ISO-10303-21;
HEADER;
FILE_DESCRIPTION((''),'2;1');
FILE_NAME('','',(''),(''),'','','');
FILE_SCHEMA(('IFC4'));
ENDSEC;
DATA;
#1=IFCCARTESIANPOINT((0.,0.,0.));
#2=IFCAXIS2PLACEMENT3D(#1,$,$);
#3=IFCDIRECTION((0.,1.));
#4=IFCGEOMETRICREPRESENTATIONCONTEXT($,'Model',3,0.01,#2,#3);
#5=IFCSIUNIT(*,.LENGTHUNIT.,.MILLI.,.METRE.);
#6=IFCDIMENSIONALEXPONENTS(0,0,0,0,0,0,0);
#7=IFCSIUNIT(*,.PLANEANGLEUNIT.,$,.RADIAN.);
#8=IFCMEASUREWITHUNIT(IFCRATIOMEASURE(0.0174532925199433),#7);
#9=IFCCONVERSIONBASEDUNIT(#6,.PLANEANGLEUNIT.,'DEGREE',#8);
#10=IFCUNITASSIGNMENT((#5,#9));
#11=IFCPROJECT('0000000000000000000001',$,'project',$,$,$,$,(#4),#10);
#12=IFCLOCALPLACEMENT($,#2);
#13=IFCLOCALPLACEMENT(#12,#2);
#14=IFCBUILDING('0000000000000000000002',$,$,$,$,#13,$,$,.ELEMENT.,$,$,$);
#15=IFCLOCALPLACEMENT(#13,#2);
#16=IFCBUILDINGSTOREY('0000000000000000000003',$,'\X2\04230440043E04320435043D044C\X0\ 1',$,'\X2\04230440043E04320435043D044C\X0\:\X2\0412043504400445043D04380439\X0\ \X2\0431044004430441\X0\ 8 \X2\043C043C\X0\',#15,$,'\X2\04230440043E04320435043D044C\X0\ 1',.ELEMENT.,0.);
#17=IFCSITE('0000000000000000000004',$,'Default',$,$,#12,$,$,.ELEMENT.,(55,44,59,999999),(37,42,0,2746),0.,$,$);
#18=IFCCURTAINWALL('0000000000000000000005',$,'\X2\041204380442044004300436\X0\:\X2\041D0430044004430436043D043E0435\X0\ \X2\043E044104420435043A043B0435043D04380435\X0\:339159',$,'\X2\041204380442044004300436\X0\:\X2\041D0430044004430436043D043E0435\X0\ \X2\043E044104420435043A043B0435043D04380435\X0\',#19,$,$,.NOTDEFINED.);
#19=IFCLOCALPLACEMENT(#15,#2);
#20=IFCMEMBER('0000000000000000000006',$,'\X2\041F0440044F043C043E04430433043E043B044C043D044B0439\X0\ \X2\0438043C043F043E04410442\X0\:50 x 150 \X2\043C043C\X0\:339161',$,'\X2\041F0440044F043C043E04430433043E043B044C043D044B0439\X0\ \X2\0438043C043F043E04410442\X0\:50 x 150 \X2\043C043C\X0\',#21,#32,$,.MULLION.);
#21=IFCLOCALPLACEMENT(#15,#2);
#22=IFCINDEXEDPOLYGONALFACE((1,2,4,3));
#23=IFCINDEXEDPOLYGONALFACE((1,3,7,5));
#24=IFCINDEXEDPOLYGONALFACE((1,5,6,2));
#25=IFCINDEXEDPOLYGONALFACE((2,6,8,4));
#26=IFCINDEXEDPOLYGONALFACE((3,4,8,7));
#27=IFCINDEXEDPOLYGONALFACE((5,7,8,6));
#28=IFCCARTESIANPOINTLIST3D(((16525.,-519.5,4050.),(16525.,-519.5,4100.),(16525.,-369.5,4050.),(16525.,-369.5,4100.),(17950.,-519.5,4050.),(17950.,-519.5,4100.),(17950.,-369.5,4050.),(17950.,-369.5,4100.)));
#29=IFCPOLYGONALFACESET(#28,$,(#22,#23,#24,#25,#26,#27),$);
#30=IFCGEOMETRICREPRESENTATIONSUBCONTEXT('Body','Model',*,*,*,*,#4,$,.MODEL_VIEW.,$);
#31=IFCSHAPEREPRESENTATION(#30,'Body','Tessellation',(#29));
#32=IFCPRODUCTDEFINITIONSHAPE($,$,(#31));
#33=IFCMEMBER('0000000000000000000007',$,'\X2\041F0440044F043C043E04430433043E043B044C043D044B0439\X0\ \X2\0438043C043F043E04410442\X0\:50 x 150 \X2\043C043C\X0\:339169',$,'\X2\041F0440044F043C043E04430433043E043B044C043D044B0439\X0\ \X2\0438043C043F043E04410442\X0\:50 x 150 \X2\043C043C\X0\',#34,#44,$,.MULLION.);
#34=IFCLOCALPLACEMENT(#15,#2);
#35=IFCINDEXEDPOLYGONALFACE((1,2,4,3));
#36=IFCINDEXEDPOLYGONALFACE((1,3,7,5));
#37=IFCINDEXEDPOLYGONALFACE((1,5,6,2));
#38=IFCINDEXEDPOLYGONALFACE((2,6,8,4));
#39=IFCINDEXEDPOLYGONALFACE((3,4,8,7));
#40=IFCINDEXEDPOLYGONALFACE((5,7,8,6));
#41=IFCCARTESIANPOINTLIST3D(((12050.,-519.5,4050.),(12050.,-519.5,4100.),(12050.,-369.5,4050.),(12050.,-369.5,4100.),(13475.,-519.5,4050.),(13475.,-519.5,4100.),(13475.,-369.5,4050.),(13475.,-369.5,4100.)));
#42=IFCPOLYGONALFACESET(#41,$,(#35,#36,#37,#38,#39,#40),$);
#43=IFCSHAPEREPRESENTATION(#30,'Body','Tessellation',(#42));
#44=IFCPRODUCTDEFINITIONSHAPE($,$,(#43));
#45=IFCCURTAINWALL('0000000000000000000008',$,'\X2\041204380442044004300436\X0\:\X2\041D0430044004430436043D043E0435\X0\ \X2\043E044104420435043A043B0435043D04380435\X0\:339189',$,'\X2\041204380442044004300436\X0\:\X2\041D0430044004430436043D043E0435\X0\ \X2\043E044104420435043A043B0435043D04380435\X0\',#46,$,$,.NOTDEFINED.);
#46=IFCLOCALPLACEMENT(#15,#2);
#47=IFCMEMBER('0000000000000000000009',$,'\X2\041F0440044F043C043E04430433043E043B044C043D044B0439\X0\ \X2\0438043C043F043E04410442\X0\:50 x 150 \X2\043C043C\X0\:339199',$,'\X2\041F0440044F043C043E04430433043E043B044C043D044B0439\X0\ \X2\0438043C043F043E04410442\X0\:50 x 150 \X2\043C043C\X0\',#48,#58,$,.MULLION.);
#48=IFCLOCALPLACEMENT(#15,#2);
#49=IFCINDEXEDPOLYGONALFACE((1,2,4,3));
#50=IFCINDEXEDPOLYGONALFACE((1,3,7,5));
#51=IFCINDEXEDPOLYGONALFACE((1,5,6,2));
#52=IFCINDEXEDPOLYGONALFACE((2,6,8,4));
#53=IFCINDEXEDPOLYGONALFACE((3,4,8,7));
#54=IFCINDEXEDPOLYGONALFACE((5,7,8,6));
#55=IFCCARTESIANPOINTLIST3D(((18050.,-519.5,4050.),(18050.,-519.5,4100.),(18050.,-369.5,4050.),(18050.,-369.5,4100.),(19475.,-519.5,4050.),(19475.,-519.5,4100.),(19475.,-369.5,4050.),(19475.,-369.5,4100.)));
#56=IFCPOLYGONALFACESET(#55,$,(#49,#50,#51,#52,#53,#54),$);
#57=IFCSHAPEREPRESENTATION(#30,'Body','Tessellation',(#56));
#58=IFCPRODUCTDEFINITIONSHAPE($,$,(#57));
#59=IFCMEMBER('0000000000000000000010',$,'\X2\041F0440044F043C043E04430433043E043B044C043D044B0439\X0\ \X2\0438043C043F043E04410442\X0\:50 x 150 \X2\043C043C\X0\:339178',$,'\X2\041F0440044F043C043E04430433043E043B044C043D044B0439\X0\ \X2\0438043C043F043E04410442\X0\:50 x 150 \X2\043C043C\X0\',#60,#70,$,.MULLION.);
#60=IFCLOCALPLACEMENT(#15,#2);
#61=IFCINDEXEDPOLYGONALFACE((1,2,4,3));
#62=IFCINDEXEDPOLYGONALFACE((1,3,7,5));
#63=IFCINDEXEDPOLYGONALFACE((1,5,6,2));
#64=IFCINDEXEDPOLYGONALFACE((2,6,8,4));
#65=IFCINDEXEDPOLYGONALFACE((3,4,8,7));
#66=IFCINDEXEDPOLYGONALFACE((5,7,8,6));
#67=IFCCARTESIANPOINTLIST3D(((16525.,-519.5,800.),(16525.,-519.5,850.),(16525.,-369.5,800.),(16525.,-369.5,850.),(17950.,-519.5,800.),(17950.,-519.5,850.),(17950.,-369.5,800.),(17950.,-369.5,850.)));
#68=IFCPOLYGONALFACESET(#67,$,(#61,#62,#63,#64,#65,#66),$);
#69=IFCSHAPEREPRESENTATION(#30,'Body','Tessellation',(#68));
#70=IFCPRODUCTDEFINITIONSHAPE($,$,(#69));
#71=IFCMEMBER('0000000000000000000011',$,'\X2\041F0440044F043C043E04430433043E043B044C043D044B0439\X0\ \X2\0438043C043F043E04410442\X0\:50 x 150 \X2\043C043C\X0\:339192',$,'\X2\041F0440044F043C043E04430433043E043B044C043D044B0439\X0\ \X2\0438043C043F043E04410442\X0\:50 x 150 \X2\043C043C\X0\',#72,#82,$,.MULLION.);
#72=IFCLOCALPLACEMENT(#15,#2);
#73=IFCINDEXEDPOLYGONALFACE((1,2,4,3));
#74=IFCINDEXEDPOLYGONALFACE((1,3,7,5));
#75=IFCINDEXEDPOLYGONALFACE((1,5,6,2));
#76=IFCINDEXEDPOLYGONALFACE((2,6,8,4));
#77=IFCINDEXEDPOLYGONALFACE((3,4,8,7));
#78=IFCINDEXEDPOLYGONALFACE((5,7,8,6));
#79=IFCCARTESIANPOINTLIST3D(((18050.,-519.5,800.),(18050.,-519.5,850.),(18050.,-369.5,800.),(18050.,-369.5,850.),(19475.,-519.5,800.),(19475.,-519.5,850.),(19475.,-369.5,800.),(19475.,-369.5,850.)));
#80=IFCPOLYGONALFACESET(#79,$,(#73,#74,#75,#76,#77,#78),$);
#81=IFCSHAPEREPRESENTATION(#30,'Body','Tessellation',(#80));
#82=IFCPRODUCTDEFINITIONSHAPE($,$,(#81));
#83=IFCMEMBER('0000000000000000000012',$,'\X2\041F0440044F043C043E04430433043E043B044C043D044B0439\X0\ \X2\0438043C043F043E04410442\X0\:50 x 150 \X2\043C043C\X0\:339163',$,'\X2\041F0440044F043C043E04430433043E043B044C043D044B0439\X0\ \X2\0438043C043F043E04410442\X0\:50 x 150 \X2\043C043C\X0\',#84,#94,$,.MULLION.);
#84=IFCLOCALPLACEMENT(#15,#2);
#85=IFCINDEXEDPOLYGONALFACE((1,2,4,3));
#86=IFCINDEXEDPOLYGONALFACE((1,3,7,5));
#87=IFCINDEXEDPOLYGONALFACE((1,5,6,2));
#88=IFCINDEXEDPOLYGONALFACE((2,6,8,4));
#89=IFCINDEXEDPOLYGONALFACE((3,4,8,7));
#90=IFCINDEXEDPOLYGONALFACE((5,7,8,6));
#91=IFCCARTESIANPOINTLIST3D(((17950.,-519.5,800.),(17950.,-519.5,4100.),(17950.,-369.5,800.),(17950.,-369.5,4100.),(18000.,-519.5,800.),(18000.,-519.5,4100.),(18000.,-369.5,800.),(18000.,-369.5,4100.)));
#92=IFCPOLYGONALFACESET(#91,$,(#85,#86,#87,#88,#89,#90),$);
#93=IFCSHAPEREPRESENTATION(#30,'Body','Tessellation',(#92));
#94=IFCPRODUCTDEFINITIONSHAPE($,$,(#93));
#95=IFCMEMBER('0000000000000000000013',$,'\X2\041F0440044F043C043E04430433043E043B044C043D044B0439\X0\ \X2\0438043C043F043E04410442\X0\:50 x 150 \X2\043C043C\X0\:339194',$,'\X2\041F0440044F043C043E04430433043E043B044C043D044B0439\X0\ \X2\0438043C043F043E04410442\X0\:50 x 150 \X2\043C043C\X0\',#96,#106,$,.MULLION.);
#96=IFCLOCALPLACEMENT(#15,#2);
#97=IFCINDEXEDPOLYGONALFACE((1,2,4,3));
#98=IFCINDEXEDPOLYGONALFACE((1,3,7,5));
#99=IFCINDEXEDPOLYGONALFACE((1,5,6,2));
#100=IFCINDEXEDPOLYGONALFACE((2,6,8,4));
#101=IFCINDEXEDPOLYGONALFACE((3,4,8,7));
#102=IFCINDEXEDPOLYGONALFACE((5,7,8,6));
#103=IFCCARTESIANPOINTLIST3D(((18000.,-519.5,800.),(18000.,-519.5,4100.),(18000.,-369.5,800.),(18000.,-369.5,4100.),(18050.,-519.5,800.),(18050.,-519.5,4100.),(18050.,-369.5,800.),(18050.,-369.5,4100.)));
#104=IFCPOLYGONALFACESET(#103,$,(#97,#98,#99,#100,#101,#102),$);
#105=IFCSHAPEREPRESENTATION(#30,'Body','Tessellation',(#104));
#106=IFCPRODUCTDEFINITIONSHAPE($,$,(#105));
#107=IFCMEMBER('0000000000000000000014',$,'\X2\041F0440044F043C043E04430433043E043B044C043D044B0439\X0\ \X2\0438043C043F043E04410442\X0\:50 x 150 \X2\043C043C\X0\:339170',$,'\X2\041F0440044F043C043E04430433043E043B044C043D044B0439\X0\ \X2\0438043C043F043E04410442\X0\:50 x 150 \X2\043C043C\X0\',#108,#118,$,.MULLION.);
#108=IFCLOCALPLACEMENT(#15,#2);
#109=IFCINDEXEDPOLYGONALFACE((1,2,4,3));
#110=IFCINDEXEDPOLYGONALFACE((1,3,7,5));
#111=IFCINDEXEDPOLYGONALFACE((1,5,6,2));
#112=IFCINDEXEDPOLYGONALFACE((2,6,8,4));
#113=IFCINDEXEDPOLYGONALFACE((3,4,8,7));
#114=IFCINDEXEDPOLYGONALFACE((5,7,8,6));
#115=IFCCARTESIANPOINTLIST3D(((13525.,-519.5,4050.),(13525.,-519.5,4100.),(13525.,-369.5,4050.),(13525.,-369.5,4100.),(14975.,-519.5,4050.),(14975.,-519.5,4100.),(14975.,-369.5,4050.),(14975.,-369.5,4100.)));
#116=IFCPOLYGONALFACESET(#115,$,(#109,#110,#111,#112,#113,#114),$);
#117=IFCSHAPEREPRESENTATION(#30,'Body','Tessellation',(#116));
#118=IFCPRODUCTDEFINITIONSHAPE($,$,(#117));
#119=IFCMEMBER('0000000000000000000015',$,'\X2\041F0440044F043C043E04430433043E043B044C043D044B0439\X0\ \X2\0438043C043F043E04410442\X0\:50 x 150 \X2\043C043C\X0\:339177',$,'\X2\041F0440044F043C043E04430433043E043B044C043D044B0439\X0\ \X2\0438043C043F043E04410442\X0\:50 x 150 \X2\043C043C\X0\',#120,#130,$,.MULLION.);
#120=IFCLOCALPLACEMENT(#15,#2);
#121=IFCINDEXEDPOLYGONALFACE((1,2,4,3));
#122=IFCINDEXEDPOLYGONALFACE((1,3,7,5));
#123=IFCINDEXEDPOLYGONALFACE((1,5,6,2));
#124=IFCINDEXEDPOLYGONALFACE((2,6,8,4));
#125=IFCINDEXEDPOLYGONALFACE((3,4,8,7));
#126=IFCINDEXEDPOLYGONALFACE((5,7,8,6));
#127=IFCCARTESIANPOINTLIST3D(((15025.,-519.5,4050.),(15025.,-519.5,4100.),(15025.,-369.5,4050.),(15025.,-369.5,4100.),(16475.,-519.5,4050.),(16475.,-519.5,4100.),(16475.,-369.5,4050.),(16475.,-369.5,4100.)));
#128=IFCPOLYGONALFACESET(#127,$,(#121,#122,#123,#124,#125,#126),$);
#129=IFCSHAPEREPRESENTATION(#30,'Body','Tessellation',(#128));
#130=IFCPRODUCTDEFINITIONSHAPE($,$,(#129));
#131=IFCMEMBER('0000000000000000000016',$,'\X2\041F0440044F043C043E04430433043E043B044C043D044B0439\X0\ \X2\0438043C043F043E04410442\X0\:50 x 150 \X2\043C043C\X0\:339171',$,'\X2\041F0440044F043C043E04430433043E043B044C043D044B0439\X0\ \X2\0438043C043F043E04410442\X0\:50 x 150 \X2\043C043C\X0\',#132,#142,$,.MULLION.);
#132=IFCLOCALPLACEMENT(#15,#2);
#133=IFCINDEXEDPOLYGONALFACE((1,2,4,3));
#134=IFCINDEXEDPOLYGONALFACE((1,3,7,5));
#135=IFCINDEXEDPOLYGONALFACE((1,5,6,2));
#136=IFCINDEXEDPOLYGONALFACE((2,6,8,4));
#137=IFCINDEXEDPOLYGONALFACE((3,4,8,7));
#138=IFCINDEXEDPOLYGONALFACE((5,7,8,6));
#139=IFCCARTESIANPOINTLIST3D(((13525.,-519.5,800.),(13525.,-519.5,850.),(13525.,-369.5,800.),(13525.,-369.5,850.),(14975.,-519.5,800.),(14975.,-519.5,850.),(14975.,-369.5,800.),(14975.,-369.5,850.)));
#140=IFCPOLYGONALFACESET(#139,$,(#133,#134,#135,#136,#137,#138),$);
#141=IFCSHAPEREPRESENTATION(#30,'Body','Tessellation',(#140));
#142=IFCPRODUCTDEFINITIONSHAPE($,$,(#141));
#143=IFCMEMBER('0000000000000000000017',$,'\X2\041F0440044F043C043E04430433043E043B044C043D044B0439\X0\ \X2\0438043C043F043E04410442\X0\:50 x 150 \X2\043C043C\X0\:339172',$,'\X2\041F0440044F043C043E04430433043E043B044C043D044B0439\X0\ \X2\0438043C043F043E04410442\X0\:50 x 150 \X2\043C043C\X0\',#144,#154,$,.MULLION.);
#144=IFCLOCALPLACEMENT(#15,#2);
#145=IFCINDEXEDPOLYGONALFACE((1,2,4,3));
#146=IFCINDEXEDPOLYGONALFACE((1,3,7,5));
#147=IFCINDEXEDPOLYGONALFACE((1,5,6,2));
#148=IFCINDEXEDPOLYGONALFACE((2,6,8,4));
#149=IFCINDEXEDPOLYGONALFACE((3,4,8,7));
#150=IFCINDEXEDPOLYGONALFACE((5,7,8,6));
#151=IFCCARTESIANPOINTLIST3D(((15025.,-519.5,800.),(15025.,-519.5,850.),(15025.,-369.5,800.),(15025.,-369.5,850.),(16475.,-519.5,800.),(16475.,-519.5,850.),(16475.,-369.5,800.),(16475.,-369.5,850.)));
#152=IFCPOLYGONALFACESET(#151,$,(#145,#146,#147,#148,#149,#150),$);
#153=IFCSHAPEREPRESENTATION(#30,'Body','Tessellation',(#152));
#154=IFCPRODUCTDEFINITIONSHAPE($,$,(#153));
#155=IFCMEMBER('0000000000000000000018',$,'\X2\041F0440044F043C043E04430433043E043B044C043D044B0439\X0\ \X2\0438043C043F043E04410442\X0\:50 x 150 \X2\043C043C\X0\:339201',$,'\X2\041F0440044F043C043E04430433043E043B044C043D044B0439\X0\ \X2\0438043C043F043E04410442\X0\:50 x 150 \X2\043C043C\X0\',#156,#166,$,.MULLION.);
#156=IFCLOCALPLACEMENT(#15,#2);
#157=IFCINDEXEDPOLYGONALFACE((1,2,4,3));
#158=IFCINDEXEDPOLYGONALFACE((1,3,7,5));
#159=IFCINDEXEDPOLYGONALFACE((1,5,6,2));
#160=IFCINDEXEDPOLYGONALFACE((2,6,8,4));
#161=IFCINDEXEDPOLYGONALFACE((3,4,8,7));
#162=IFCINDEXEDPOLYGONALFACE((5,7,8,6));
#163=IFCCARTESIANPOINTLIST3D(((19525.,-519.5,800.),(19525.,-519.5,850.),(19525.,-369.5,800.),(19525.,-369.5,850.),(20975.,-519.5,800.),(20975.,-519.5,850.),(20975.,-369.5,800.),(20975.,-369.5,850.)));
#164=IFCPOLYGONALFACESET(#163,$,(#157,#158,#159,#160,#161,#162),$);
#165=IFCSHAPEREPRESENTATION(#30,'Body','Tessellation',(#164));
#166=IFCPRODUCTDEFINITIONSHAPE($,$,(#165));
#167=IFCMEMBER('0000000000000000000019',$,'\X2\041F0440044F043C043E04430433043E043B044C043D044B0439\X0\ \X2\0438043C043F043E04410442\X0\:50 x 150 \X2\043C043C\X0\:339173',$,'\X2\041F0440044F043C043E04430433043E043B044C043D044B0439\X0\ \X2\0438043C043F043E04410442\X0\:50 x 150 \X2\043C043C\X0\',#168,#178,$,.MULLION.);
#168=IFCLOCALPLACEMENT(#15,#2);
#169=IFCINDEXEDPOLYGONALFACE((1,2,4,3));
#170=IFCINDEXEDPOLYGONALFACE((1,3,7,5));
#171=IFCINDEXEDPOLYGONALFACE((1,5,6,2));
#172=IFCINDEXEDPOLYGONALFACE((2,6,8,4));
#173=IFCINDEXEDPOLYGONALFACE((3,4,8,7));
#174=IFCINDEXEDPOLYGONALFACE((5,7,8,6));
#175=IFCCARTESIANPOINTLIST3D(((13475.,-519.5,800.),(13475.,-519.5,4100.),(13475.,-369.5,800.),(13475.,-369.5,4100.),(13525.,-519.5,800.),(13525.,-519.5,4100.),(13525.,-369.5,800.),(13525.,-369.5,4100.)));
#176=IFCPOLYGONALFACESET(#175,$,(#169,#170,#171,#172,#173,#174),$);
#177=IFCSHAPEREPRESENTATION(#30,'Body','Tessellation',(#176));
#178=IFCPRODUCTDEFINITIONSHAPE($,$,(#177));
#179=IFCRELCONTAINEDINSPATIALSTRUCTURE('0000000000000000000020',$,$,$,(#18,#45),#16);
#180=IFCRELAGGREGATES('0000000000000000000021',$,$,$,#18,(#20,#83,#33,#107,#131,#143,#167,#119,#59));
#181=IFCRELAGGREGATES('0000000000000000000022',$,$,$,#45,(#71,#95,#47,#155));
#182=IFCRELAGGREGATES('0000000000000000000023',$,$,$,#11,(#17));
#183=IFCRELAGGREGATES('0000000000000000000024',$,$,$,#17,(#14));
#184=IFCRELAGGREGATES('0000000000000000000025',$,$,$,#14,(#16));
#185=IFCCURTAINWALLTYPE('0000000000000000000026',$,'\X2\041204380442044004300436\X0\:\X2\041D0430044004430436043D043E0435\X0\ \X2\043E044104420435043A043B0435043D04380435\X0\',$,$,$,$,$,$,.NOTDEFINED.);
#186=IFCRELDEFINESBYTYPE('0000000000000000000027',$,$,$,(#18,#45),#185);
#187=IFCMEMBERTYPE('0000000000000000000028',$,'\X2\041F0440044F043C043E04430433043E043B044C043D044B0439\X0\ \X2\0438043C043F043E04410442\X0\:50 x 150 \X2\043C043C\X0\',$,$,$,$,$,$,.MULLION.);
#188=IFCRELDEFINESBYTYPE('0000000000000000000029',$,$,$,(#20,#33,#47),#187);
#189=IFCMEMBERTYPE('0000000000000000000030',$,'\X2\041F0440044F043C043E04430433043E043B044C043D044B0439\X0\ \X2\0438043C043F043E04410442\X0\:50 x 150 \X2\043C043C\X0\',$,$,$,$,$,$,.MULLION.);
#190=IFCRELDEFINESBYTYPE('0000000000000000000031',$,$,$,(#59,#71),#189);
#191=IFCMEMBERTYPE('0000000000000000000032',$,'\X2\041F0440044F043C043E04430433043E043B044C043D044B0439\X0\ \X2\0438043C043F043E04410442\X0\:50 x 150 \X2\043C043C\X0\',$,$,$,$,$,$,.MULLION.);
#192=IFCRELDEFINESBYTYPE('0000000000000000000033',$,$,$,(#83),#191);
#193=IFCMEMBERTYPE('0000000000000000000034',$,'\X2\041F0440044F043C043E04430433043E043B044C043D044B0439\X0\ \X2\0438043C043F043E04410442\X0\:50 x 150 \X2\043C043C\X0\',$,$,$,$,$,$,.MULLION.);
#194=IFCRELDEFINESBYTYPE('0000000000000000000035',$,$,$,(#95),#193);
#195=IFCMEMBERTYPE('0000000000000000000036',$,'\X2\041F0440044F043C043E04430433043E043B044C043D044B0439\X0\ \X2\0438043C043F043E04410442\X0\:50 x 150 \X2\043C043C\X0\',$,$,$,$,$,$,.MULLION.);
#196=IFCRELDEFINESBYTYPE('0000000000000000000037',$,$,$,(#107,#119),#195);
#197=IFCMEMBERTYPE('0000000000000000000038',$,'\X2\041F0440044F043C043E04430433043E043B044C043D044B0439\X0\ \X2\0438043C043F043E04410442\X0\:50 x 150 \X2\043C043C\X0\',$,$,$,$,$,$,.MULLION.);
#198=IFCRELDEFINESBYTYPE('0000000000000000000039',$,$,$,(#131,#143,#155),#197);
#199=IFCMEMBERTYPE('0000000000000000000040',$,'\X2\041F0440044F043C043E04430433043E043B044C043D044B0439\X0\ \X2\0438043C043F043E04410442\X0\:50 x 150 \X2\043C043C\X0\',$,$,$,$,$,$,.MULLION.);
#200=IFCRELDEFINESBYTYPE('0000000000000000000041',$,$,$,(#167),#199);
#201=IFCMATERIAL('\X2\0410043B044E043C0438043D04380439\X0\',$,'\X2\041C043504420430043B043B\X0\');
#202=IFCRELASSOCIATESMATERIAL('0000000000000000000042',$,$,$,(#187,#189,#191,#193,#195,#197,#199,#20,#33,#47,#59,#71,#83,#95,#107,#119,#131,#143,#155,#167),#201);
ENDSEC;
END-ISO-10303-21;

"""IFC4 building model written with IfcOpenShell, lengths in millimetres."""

from ifc_helpers import new_model, entity, si_unit, converted_unit, direction, frame, origin, origin_2d_with_axis, place, context, subcontext, project, spatial, rectangle, extrude, source, transform, mapped, material, material_profile, profile_set, profile_usage, type_object, type_shapes, element, aggregate, save


model = new_model("IFC4")

# Units and contexts
model_context = context("Model", 3, precision=0.01, world=origin(), true_north=direction((0.0, 1.0)))
body_context = subcontext(model_context, "Body", "Model", "MODEL_VIEW")
ifc_project = project(units=[si_unit("LENGTHUNIT", "METRE", prefix="MILLI"), converted_unit("PLANEANGLEUNIT", "DEGREE", entity("IfcRatioMeasure", 0.0174532925199433), si_unit("PLANEANGLEUNIT", "RADIAN"), dimensions=[0, 0, 0, 0, 0, 0, 0])], contexts=[model_context])

# Site, building, storey
site_placement = place(None, origin())
site = spatial("IfcSite", under=ifc_project, at=site_placement, Name="Default", CompositionType="ELEMENT", RefLatitude=(55, 44, 59, 999999), RefLongitude=(37, 42, 0, 2746), RefElevation=0.0)
building_placement = place(site_placement, origin())
building = spatial("IfcBuilding", under=site, at=building_placement, CompositionType="ELEMENT")
storey_placement = place(building_placement, origin())
storey = spatial("IfcBuildingStorey", under=building, at=storey_placement, Name="Уровень 1", ObjectType="Уровень:Верхний брус 8 мм", LongName="Уровень 1", CompositionType="ELEMENT", Elevation=0.0)

# Curtain wall, members
curtain_wall_type = type_object("IfcCurtainWallType", Name="Витраж:Наружное остекление", PredefinedType="NOTDEFINED")
curtain_wall_1_placement = place(storey_placement, origin())
curtain_wall_1 = element("IfcCurtainWall", 1, at=curtain_wall_1_placement, inside=storey, type_object=curtain_wall_type, Name="Витраж:Наружное остекление:339159", ObjectType="Витраж:Наружное остекление", PredefinedType="NOTDEFINED")
ifc_material_1 = material(Name="Алюминий", Category="Металл")
ifc_material_profile = material_profile(ifc_material_1, rectangle(XDim=150.0, YDim=50.0, at=origin_2d_with_axis()), Name="50 x 150 мм")
ifc_profile_set = profile_set([ifc_material_profile], Name="50 x 150 мм")
ifc_profile_usage_1 = profile_usage(ifc_profile_set)
member_type_1 = type_object("IfcMemberType", Name="Прямоугольный импост:50 x 150 мм", PredefinedType="MULLION", material=ifc_profile_set)
shared_shape_1 = source(origin(), body_context, "Body", "SweptSolid", [
    extrude(rectangle(XDim=150.0, YDim=50.0, at=origin_2d_with_axis()), frame((-25.0, 0.0, -1425.0), z_axis=(0.0, 0.0, 1.0), x_axis=(0.0, -1.0, 0.0)), (0.0, 0.0, 1.0), 1425.0),
])
type_shapes(member_type_1, [shared_shape_1])
member_1_placement = place(storey_placement, frame((17950.0, -444.5, 4100.0), z_axis=(1.0, 0.0, 0.0), x_axis=(0.0, 0.0, 1.0)))
member_1 = element("IfcMember", 2, at=member_1_placement, type_object=member_type_1, material=ifc_profile_usage_1, Name="Прямоугольный импост:50 x 150 мм:339161", ObjectType="Прямоугольный импост:50 x 150 мм", PredefinedType="MULLION", context=body_context, shape_type="MappedRepresentation", body=[
    mapped(shared_shape_1, transform((0.0, 0.0, 0.0), scale=1.0)),
])
ifc_profile_usage_2 = profile_usage(ifc_profile_set)
member_2_placement = place(storey_placement, frame((13475.0, -444.5, 4100.0), z_axis=(1.0, 0.0, 0.0), x_axis=(0.0, 0.0, 1.0)))
member_2 = element("IfcMember", 3, at=member_2_placement, type_object=member_type_1, material=ifc_profile_usage_2, Name="Прямоугольный импост:50 x 150 мм:339169", ObjectType="Прямоугольный импост:50 x 150 мм", PredefinedType="MULLION", context=body_context, shape_type="MappedRepresentation", body=[
    mapped(shared_shape_1, transform((0.0, 0.0, 0.0), scale=1.0)),
])

# Curtain wall, member
curtain_wall_2_placement = place(storey_placement, origin())
curtain_wall_2 = element("IfcCurtainWall", 4, at=curtain_wall_2_placement, inside=storey, type_object=curtain_wall_type, Name="Витраж:Наружное остекление:339189", ObjectType="Витраж:Наружное остекление", PredefinedType="NOTDEFINED")
ifc_profile_usage_3 = profile_usage(ifc_profile_set)
member_3_placement = place(storey_placement, frame((19475.0, -444.5, 4100.0), z_axis=(1.0, 0.0, 0.0), x_axis=(0.0, 0.0, 1.0)))
member_3 = element("IfcMember", 5, at=member_3_placement, type_object=member_type_1, material=ifc_profile_usage_3, Name="Прямоугольный импост:50 x 150 мм:339199", ObjectType="Прямоугольный импост:50 x 150 мм", PredefinedType="MULLION", context=body_context, shape_type="MappedRepresentation", body=[
    mapped(shared_shape_1, transform((0.0, 0.0, 0.0), scale=1.0)),
])

# Members
ifc_profile_usage_4 = profile_usage(ifc_profile_set)
member_type_2 = type_object("IfcMemberType", Name="Прямоугольный импост:50 x 150 мм", PredefinedType="MULLION", material=ifc_profile_set)
shared_shape_2 = source(origin(), body_context, "Body", "SweptSolid", [
    extrude(rectangle(XDim=150.0, YDim=50.0, at=origin_2d_with_axis()), frame((-25.0, 0.0, -1425.0), z_axis=(0.0, 0.0, 1.0), x_axis=(0.0, -1.0, 0.0)), (0.0, 0.0, 1.0), 1425.0),
])
type_shapes(member_type_2, [shared_shape_2])
member_4_placement = place(storey_placement, frame((16525.0, -444.5, 800.0), z_axis=(-1.0, 0.0, 0.0), x_axis=(0.0, 0.0, -1.0)))
member_4 = element("IfcMember", 6, at=member_4_placement, type_object=member_type_2, material=ifc_profile_usage_4, Name="Прямоугольный импост:50 x 150 мм:339178", ObjectType="Прямоугольный импост:50 x 150 мм", PredefinedType="MULLION", context=body_context, shape_type="MappedRepresentation", body=[
    mapped(shared_shape_2, transform((0.0, 0.0, 0.0), scale=1.0)),
])
ifc_profile_usage_5 = profile_usage(ifc_profile_set)
member_5_placement = place(storey_placement, frame((18050.0, -444.5, 800.0), z_axis=(-1.0, 0.0, 0.0), x_axis=(0.0, 0.0, -1.0)))
member_5 = element("IfcMember", 7, at=member_5_placement, type_object=member_type_2, material=ifc_profile_usage_5, Name="Прямоугольный импост:50 x 150 мм:339192", ObjectType="Прямоугольный импост:50 x 150 мм", PredefinedType="MULLION", context=body_context, shape_type="MappedRepresentation", body=[
    mapped(shared_shape_2, transform((0.0, 0.0, 0.0), scale=1.0)),
])
ifc_profile_usage_6 = profile_usage(ifc_profile_set)
member_type_3 = type_object("IfcMemberType", Name="Прямоугольный импост:50 x 150 мм", PredefinedType="MULLION", material=ifc_profile_set)
shared_shape_3 = source(origin(), body_context, "Body", "SweptSolid", [
    extrude(rectangle(XDim=150.0, YDim=50.0, at=origin_2d_with_axis()), frame((-25.0, 0.0, -3300.0), z_axis=(0.0, 0.0, 1.0), x_axis=(0.0, -1.0, 0.0)), (0.0, 0.0, 1.0), 3300.0),
])
type_shapes(member_type_3, [shared_shape_3])
member_6_placement = place(storey_placement, frame((18000.0, -444.5, 800.0), z_axis=(0.0, 0.0, -1.0), x_axis=(1.0, 0.0, 0.0)))
member_6 = element("IfcMember", 8, at=member_6_placement, type_object=member_type_3, material=ifc_profile_usage_6, Name="Прямоугольный импост:50 x 150 мм:339163", ObjectType="Прямоугольный импост:50 x 150 мм", PredefinedType="MULLION", context=body_context, shape_type="MappedRepresentation", body=[
    mapped(shared_shape_3, transform((0.0, 0.0, 0.0), scale=1.0)),
])
ifc_profile_usage_7 = profile_usage(ifc_profile_set)
member_type_4 = type_object("IfcMemberType", Name="Прямоугольный импост:50 x 150 мм", PredefinedType="MULLION", material=ifc_profile_set)
shared_shape_4 = source(origin(), body_context, "Body", "SweptSolid", [
    extrude(rectangle(XDim=150.0, YDim=50.0, at=origin_2d_with_axis()), frame((-25.0, 0.0, -3300.0), z_axis=(0.0, 0.0, 1.0), x_axis=(0.0, -1.0, 0.0)), (0.0, 0.0, 1.0), 3300.0),
])
type_shapes(member_type_4, [shared_shape_4])
member_7_placement = place(storey_placement, frame((18000.0, -444.5, 4100.0), z_axis=(0.0, 0.0, 1.0), x_axis=(-1.0, 0.0, 0.0)))
member_7 = element("IfcMember", 9, at=member_7_placement, type_object=member_type_4, material=ifc_profile_usage_7, Name="Прямоугольный импост:50 x 150 мм:339194", ObjectType="Прямоугольный импост:50 x 150 мм", PredefinedType="MULLION", context=body_context, shape_type="MappedRepresentation", body=[
    mapped(shared_shape_4, transform((0.0, 0.0, 0.0), scale=1.0)),
])
ifc_profile_usage_8 = profile_usage(ifc_profile_set)
member_type_5 = type_object("IfcMemberType", Name="Прямоугольный импост:50 x 150 мм", PredefinedType="MULLION", material=ifc_profile_set)
shared_shape_5 = source(origin(), body_context, "Body", "SweptSolid", [
    extrude(rectangle(XDim=150.0, YDim=50.0, at=origin_2d_with_axis()), frame((-25.0, 0.0, -1450.0), z_axis=(0.0, 0.0, 1.0), x_axis=(0.0, -1.0, 0.0)), (0.0, 0.0, 1.0), 1450.0),
])
type_shapes(member_type_5, [shared_shape_5])
member_8_placement = place(storey_placement, frame((14975.0, -444.5, 4100.0), z_axis=(1.0, 0.0, 0.0), x_axis=(0.0, 0.0, 1.0)))
member_8 = element("IfcMember", 10, at=member_8_placement, type_object=member_type_5, material=ifc_profile_usage_8, Name="Прямоугольный импост:50 x 150 мм:339170", ObjectType="Прямоугольный импост:50 x 150 мм", PredefinedType="MULLION", context=body_context, shape_type="MappedRepresentation", body=[
    mapped(shared_shape_5, transform((0.0, 0.0, 0.0), scale=1.0)),
])
ifc_profile_usage_9 = profile_usage(ifc_profile_set)
member_9_placement = place(storey_placement, frame((16475.0, -444.5, 4100.0), z_axis=(1.0, 0.0, 0.0), x_axis=(0.0, 0.0, 1.0)))
member_9 = element("IfcMember", 11, at=member_9_placement, type_object=member_type_5, material=ifc_profile_usage_9, Name="Прямоугольный импост:50 x 150 мм:339177", ObjectType="Прямоугольный импост:50 x 150 мм", PredefinedType="MULLION", context=body_context, shape_type="MappedRepresentation", body=[
    mapped(shared_shape_5, transform((0.0, 0.0, 0.0), scale=1.0)),
])
ifc_profile_usage_10 = profile_usage(ifc_profile_set)
member_type_6 = type_object("IfcMemberType", Name="Прямоугольный импост:50 x 150 мм", PredefinedType="MULLION", material=ifc_profile_set)
shared_shape_6 = source(origin(), body_context, "Body", "SweptSolid", [
    extrude(rectangle(XDim=150.0, YDim=50.0, at=origin_2d_with_axis()), frame((-25.0, 0.0, -1450.0), z_axis=(0.0, 0.0, 1.0), x_axis=(0.0, -1.0, 0.0)), (0.0, 0.0, 1.0), 1450.0),
])
type_shapes(member_type_6, [shared_shape_6])
member_10_placement = place(storey_placement, frame((13525.0, -444.5, 800.0), z_axis=(-1.0, 0.0, 0.0), x_axis=(0.0, 0.0, -1.0)))
member_10 = element("IfcMember", 12, at=member_10_placement, type_object=member_type_6, material=ifc_profile_usage_10, Name="Прямоугольный импост:50 x 150 мм:339171", ObjectType="Прямоугольный импост:50 x 150 мм", PredefinedType="MULLION", context=body_context, shape_type="MappedRepresentation", body=[
    mapped(shared_shape_6, transform((0.0, 0.0, 0.0), scale=1.0)),
])
ifc_profile_usage_11 = profile_usage(ifc_profile_set)
member_11_placement = place(storey_placement, frame((15025.0, -444.5, 800.0), z_axis=(-1.0, 0.0, 0.0), x_axis=(0.0, 0.0, -1.0)))
member_11 = element("IfcMember", 13, at=member_11_placement, type_object=member_type_6, material=ifc_profile_usage_11, Name="Прямоугольный импост:50 x 150 мм:339172", ObjectType="Прямоугольный импост:50 x 150 мм", PredefinedType="MULLION", context=body_context, shape_type="MappedRepresentation", body=[
    mapped(shared_shape_6, transform((0.0, 0.0, 0.0), scale=1.0)),
])
ifc_profile_usage_12 = profile_usage(ifc_profile_set)
member_12_placement = place(storey_placement, frame((19525.0, -444.5, 800.0), z_axis=(-1.0, 0.0, 0.0), x_axis=(0.0, 0.0, -1.0)))
member_12 = element("IfcMember", 14, at=member_12_placement, type_object=member_type_6, material=ifc_profile_usage_12, Name="Прямоугольный импост:50 x 150 мм:339201", ObjectType="Прямоугольный импост:50 x 150 мм", PredefinedType="MULLION", context=body_context, shape_type="MappedRepresentation", body=[
    mapped(shared_shape_6, transform((0.0, 0.0, 0.0), scale=1.0)),
])
ifc_profile_usage_13 = profile_usage(ifc_profile_set)
member_type_7 = type_object("IfcMemberType", Name="Прямоугольный импост:50 x 150 мм", PredefinedType="MULLION", material=ifc_profile_set)
shared_shape_7 = source(origin(), body_context, "Body", "SweptSolid", [
    extrude(rectangle(XDim=150.0, YDim=50.0, at=origin_2d_with_axis()), frame((0.0, 0.0, -3300.0), z_axis=(0.0, 0.0, 1.0), x_axis=(0.0, -1.0, 0.0)), (0.0, 0.0, 1.0), 3300.0),
])
type_shapes(member_type_7, [shared_shape_7])
member_13_placement = place(storey_placement, frame((13500.0, -444.5, 800.0), z_axis=(0.0, 0.0, -1.0), x_axis=(1.0, 0.0, 0.0)))
member_13 = element("IfcMember", 15, at=member_13_placement, type_object=member_type_7, material=ifc_profile_usage_13, Name="Прямоугольный импост:50 x 150 мм:339173", ObjectType="Прямоугольный импост:50 x 150 мм", PredefinedType="MULLION", context=body_context, shape_type="MappedRepresentation", body=[
    mapped(shared_shape_7, transform((0.0, 0.0, 0.0), scale=1.0)),
])

aggregate(curtain_wall_1, [member_1, member_6, member_2, member_8, member_10, member_11, member_13, member_9, member_4])
aggregate(curtain_wall_2, [member_5, member_7, member_3, member_12])

save(model, "model.ifc")
